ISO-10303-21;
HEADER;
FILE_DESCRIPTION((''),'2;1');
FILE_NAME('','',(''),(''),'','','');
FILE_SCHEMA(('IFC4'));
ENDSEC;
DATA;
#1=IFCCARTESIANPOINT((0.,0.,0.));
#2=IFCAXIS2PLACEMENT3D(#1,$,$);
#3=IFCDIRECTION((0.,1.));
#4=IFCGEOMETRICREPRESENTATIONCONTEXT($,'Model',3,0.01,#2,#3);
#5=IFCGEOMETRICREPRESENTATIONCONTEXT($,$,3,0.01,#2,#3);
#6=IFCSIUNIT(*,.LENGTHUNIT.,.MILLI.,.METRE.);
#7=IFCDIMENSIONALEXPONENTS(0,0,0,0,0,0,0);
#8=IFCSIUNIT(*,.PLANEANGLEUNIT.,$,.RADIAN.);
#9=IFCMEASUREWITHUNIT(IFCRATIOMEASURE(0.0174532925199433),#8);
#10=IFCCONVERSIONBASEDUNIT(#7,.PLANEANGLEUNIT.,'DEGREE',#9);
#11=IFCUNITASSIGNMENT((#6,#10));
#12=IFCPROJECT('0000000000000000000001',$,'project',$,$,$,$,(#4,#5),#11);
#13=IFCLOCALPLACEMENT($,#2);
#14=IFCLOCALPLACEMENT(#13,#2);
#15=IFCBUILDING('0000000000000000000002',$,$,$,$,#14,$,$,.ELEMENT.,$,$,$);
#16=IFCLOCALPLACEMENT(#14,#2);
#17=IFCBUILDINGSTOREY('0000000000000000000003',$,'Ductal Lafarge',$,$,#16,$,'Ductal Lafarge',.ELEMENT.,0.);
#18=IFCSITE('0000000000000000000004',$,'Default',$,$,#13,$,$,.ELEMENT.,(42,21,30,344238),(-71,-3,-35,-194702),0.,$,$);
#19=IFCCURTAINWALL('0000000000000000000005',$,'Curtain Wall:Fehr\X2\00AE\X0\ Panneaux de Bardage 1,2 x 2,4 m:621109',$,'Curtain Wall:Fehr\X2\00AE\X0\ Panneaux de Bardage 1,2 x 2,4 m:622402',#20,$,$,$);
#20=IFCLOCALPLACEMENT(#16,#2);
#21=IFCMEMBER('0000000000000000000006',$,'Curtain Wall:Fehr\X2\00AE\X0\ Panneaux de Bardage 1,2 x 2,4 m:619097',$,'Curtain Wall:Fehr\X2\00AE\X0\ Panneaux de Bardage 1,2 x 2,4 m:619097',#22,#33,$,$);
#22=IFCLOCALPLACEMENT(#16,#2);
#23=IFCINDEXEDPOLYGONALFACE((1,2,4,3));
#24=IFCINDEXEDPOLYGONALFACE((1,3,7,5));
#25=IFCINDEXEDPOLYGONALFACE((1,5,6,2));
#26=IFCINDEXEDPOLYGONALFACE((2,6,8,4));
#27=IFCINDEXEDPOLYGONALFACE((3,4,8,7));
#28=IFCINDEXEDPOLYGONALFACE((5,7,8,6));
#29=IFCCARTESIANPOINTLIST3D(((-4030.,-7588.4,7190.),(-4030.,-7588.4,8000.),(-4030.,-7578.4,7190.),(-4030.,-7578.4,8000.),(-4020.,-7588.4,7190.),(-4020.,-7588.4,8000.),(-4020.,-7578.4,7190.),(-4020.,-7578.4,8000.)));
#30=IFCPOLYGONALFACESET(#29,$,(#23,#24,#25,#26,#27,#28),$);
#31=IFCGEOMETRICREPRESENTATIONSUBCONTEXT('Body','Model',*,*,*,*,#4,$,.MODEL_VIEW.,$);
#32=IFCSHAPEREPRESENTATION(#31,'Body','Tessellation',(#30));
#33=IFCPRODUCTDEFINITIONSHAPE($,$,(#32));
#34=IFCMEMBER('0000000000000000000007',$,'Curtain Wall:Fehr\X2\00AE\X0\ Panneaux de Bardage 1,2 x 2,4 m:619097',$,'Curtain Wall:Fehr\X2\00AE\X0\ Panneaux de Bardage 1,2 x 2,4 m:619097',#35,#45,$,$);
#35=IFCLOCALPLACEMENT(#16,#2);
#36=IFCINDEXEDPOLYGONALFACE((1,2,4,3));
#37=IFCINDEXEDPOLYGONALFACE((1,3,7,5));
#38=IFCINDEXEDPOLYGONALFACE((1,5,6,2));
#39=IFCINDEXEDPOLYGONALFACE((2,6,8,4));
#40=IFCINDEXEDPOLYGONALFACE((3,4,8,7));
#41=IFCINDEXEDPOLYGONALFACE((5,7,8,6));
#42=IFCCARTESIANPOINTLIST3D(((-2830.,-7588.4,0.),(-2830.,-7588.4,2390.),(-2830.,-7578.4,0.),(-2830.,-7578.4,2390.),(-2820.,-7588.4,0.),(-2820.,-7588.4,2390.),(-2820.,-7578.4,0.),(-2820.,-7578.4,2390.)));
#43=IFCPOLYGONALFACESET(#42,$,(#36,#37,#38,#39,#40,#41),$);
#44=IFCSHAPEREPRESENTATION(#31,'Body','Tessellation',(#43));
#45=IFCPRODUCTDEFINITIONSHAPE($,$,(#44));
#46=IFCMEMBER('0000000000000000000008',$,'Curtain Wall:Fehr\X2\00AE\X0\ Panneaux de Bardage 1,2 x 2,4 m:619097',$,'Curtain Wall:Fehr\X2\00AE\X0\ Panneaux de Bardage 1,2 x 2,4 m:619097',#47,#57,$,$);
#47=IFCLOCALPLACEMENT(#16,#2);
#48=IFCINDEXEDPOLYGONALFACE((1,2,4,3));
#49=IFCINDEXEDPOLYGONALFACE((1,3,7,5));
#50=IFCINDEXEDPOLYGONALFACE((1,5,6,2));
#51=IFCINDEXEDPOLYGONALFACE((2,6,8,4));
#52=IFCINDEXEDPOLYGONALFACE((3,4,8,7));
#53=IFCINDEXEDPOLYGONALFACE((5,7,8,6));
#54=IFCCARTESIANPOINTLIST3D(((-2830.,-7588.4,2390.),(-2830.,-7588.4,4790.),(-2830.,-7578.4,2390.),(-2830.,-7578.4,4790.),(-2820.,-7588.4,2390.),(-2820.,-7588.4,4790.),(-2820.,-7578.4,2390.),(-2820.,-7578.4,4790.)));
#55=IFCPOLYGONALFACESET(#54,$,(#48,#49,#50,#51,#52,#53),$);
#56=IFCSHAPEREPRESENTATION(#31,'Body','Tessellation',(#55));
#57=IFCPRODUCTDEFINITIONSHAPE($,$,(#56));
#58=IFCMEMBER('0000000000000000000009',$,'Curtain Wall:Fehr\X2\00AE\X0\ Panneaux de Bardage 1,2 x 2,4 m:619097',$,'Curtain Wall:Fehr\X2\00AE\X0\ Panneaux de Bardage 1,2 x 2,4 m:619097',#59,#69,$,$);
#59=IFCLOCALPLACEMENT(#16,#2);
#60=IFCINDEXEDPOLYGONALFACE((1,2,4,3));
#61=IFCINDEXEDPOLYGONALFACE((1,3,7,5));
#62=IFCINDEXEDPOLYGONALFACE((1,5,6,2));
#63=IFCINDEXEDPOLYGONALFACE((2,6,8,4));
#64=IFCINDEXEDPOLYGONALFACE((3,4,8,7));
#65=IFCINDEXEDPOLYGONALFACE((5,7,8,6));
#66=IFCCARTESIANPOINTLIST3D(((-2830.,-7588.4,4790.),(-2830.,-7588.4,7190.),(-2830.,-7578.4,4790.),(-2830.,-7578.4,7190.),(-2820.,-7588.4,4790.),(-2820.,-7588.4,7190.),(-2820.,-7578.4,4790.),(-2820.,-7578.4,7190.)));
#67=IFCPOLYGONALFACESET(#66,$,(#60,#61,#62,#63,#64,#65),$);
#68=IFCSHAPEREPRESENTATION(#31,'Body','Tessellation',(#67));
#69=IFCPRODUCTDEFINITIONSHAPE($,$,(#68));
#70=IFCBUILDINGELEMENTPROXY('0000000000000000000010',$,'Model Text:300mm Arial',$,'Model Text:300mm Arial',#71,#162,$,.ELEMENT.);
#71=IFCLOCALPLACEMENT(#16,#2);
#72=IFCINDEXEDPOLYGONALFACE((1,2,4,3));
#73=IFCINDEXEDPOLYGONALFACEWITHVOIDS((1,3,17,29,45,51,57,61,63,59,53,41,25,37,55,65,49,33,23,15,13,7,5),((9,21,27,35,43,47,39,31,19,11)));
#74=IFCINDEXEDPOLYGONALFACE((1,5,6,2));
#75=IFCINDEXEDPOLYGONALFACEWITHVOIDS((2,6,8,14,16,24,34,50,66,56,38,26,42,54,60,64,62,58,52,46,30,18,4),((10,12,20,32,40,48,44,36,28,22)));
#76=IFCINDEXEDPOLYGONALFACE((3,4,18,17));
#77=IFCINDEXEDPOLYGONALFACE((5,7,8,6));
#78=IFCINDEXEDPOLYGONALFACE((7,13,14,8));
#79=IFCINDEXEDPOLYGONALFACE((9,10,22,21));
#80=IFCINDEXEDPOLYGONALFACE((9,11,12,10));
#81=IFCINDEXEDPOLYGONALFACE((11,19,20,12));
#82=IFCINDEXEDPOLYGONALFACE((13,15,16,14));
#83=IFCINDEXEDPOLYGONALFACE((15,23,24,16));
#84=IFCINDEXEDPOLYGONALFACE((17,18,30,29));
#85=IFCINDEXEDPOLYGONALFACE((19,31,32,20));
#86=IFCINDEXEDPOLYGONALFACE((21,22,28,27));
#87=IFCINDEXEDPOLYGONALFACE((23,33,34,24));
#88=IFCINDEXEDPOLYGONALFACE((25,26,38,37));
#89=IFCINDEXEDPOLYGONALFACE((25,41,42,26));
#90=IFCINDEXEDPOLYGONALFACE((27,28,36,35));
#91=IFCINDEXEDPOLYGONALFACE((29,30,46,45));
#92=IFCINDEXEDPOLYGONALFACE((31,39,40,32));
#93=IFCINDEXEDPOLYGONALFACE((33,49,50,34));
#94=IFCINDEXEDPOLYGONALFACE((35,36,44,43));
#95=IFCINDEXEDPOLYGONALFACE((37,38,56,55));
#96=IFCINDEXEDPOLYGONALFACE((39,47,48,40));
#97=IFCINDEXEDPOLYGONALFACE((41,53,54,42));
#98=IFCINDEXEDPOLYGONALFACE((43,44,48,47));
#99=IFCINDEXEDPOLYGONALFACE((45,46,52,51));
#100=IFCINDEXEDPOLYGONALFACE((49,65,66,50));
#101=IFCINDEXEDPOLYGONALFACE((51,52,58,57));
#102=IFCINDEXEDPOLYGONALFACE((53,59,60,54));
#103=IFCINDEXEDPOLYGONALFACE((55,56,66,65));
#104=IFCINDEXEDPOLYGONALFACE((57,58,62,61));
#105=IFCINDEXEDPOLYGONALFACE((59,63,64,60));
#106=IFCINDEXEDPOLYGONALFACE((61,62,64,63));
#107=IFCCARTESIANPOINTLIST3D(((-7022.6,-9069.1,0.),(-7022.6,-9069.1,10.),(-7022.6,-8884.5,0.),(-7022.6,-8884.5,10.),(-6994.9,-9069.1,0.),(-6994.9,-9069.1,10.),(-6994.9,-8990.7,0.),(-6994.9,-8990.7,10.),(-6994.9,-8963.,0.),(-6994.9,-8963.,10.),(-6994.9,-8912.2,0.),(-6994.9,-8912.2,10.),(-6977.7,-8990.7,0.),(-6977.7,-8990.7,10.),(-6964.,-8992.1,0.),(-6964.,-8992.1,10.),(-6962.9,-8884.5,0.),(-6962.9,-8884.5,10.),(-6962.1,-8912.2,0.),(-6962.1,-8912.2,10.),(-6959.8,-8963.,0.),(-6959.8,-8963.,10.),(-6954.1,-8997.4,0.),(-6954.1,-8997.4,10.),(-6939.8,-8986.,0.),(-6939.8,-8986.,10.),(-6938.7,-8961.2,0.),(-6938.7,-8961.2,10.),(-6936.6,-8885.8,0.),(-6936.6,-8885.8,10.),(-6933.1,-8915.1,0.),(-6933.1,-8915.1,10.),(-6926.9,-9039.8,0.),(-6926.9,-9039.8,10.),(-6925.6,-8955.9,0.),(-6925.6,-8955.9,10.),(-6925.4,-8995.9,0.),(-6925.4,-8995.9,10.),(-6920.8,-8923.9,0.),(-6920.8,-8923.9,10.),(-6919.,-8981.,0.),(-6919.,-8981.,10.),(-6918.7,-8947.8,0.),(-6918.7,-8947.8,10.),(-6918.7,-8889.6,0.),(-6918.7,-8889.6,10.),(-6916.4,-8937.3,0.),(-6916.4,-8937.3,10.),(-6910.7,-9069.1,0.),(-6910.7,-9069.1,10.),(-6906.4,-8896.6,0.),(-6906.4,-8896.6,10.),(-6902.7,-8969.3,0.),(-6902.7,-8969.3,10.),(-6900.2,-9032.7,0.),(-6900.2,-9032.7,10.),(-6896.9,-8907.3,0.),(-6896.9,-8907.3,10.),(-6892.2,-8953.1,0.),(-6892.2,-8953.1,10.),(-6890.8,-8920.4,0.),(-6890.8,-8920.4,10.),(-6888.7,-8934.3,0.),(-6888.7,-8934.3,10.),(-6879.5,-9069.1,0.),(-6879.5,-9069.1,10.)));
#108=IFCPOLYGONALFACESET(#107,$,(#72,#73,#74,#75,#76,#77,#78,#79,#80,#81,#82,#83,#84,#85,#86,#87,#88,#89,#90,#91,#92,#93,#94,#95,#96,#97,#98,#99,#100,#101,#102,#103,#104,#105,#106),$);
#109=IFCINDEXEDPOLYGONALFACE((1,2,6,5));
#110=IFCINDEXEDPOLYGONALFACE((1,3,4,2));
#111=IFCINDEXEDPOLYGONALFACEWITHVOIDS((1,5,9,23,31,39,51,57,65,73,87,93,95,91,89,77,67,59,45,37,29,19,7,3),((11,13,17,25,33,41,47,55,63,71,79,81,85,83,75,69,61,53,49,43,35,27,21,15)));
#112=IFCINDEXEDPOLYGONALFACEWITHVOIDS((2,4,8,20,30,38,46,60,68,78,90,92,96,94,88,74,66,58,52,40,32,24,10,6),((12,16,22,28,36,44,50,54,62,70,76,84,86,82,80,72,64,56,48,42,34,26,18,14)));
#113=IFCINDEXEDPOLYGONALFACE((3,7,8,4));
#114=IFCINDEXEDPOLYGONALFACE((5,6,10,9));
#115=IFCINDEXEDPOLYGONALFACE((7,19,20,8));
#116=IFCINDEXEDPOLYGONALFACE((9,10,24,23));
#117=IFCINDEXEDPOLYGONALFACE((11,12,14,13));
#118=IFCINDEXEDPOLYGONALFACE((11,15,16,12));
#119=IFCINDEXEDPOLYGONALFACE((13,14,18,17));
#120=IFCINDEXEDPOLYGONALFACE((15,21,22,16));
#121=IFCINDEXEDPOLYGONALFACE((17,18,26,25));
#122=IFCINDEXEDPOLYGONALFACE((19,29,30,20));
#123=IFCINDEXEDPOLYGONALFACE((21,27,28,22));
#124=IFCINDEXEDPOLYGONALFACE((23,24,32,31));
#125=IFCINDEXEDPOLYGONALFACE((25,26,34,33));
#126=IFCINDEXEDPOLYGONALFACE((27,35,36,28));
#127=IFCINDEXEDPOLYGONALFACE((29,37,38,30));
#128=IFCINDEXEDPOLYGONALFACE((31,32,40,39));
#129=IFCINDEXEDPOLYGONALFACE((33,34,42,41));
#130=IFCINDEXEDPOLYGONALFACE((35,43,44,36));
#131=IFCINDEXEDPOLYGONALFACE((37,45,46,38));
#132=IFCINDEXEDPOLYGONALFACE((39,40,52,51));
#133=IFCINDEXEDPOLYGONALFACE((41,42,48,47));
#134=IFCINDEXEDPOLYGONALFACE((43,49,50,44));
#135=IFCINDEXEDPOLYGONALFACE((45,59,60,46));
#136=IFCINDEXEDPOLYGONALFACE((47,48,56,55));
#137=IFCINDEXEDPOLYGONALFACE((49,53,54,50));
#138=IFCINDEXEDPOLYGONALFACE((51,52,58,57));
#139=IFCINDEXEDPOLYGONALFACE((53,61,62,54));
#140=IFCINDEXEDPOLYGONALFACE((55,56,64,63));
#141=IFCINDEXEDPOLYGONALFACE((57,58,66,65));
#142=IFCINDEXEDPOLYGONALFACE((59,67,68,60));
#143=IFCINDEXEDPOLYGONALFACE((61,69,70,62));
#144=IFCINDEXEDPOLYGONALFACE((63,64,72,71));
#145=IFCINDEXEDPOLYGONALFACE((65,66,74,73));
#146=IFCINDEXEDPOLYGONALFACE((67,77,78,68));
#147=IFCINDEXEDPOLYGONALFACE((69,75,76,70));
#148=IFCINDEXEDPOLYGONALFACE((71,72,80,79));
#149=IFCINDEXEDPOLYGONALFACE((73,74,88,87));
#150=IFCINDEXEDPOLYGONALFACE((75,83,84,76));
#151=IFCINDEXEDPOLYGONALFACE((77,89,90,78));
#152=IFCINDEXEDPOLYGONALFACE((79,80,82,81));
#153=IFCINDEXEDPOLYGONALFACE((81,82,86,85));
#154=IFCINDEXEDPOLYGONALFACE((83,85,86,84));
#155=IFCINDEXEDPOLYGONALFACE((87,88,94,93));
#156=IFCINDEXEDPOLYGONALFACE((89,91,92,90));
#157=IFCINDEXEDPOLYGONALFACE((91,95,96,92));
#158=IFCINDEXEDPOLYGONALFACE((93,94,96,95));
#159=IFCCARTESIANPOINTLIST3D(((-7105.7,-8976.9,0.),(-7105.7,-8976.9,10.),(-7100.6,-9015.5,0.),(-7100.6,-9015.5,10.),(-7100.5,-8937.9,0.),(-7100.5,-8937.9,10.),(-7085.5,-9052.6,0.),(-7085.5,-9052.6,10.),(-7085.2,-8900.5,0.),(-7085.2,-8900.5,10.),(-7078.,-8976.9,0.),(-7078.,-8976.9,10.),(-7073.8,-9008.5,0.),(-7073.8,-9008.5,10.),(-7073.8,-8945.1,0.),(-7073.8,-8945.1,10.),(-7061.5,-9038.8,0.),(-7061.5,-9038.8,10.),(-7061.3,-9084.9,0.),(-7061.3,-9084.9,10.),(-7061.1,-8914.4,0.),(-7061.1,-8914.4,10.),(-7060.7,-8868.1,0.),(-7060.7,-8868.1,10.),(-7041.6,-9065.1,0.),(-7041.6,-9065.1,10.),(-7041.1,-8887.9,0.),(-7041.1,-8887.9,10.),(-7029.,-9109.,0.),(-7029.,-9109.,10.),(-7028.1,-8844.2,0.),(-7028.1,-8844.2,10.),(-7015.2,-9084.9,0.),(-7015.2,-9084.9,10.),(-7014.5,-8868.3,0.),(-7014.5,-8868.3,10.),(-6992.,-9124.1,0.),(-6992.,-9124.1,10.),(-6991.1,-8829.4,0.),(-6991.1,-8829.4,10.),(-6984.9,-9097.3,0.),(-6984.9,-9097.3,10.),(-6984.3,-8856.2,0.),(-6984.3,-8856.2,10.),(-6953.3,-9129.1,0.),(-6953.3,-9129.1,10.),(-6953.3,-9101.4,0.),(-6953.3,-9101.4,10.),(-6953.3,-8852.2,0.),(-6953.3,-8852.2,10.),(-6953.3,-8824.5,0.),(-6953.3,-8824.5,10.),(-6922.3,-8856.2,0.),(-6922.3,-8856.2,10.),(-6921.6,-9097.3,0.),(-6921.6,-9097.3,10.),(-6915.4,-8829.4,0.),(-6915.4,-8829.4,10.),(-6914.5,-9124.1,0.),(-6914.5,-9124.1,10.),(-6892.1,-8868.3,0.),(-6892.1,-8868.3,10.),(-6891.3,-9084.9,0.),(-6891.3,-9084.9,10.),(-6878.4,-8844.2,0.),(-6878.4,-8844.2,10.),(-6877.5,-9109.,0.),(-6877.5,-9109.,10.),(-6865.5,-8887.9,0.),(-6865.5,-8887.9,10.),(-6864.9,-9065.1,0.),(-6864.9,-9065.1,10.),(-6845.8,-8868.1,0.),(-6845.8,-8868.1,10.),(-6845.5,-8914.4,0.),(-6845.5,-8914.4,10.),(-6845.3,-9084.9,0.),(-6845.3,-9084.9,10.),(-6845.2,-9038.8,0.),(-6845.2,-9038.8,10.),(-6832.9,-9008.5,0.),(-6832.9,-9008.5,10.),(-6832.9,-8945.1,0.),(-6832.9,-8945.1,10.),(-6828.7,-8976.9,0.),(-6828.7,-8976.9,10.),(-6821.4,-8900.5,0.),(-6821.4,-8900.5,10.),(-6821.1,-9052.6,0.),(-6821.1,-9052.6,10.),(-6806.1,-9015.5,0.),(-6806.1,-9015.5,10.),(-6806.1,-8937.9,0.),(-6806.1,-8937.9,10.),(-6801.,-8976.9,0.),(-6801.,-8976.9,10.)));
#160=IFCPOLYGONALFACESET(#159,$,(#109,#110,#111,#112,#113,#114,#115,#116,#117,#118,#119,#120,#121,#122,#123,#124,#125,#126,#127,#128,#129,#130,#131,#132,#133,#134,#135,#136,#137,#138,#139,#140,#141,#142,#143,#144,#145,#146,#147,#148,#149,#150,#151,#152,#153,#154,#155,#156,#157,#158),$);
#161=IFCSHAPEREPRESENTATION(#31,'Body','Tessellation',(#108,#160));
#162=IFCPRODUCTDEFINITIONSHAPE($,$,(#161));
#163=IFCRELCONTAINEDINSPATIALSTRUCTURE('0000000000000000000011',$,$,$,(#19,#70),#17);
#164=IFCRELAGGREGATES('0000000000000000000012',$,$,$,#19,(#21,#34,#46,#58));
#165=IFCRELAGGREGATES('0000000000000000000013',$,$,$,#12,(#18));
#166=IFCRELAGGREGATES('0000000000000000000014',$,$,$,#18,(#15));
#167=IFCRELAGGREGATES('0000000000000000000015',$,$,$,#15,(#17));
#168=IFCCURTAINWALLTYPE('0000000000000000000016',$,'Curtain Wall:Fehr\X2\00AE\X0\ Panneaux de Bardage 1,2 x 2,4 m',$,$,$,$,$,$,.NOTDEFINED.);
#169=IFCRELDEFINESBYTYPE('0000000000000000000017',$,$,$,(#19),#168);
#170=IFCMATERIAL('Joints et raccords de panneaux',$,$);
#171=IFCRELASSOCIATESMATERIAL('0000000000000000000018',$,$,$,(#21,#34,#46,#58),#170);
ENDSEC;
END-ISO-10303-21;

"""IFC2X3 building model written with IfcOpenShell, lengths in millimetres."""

from ifc_helpers import new_model, entity, si_unit, converted_unit, direction, frame, origin, origin_2d_with_axis, place, context, subcontext, project, spatial, polyline, rectangle, outline, extrude, material, type_object, element, aggregate, save


model = new_model("IFC2X3")

# Units and contexts
model_context = context("Model", 3, precision=0.01, world=origin(), true_north=direction((0.0, 1.0)))
context_of_model = context(None, 3, precision=0.01, world=origin(), true_north=direction((0.0, 1.0)))
body_context = subcontext(model_context, "Body", "Model", "MODEL_VIEW")
ifc_project = project(units=[si_unit("LENGTHUNIT", "METRE", prefix="MILLI"), converted_unit("PLANEANGLEUNIT", "DEGREE", entity("IfcRatioMeasure", 0.0174532925199433), si_unit("PLANEANGLEUNIT", "RADIAN"), dimensions=[0, 0, 0, 0, 0, 0, 0])], contexts=[model_context, context_of_model])

# Site, building, storey
site_placement = place(None, origin())
site = spatial("IfcSite", under=ifc_project, at=site_placement, Name="Default", CompositionType="ELEMENT", RefLatitude=(42, 21, 30, 344238), RefLongitude=(-71, -3, -35, -194702), RefElevation=0.0)
building_placement = place(site_placement, origin())
building = spatial("IfcBuilding", under=site, at=building_placement, CompositionType="ELEMENT")
storey_placement = place(building_placement, origin())
storey = spatial("IfcBuildingStorey", under=building, at=storey_placement, Name="Ductal Lafarge", LongName="Ductal Lafarge", CompositionType="ELEMENT", Elevation=0.0)

# Curtain wall, members
curtain_wall_type = type_object("IfcCurtainWallType", Name="Curtain Wall:Fehr® Panneaux de Bardage 1,2 x 2,4 m", PredefinedType="NOTDEFINED")
curtain_wall_placement = place(storey_placement, origin())
curtain_wall = element("IfcCurtainWall", 1, at=curtain_wall_placement, inside=storey, type_object=curtain_wall_type, Name="Curtain Wall:Fehr® Panneaux de Bardage 1,2 x 2,4 m:621109", ObjectType="Curtain Wall:Fehr® Panneaux de Bardage 1,2 x 2,4 m:622402")
ifc_material = material(Name="Joints et raccords de panneaux")
member_1_placement = place(curtain_wall_placement, frame((-4030.0, -7588.4, 7190.0)))
member_1 = element("IfcMember", 2, at=member_1_placement, material=ifc_material, Name="Curtain Wall:Fehr® Panneaux de Bardage 1,2 x 2,4 m:619097", ObjectType="Curtain Wall:Fehr® Panneaux de Bardage 1,2 x 2,4 m:619097", context=body_context, shape_type="SweptSolid", body=[
    extrude(rectangle(XDim=10.0, YDim=10.0, at=origin_2d_with_axis()), frame((5.0, 5.0, 0.0), z_axis=(0.0, 0.0, 1.0), x_axis=(0.0, 1.0, 0.0)), (0.0, 0.0, 1.0), 810.0),
])
member_2_placement = place(curtain_wall_placement, frame((-2830.0, -7588.4, 0.0)))
member_2 = element("IfcMember", 3, at=member_2_placement, material=ifc_material, Name="Curtain Wall:Fehr® Panneaux de Bardage 1,2 x 2,4 m:619097", ObjectType="Curtain Wall:Fehr® Panneaux de Bardage 1,2 x 2,4 m:619097", context=body_context, shape_type="SweptSolid", body=[
    extrude(rectangle(XDim=10.0, YDim=10.0, at=origin_2d_with_axis()), frame((5.0, 5.0, 0.0), z_axis=(0.0, 0.0, 1.0), x_axis=(0.0, 1.0, 0.0)), (0.0, 0.0, 1.0), 2390.0),
])
member_3_placement = place(curtain_wall_placement, frame((-2830.0, -7588.4, 2390.0)))
member_3 = element("IfcMember", 4, at=member_3_placement, material=ifc_material, Name="Curtain Wall:Fehr® Panneaux de Bardage 1,2 x 2,4 m:619097", ObjectType="Curtain Wall:Fehr® Panneaux de Bardage 1,2 x 2,4 m:619097", context=body_context, shape_type="SweptSolid", body=[
    extrude(rectangle(XDim=10.0, YDim=10.0, at=origin_2d_with_axis()), frame((5.0, 5.0, 0.0), z_axis=(0.0, 0.0, 1.0), x_axis=(0.0, 1.0, 0.0)), (0.0, 0.0, 1.0), 2400.0),
])
member_4_placement = place(curtain_wall_placement, frame((-2830.0, -7588.4, 4790.0)))
member_4 = element("IfcMember", 5, at=member_4_placement, material=ifc_material, Name="Curtain Wall:Fehr® Panneaux de Bardage 1,2 x 2,4 m:619097", ObjectType="Curtain Wall:Fehr® Panneaux de Bardage 1,2 x 2,4 m:619097", context=body_context, shape_type="SweptSolid", body=[
    extrude(rectangle(XDim=10.0, YDim=10.0, at=origin_2d_with_axis()), frame((5.0, 5.0, 0.0), z_axis=(0.0, 0.0, 1.0), x_axis=(0.0, 1.0, 0.0)), (0.0, 0.0, 1.0), 2400.0),
])
aggregate(curtain_wall, [member_1, member_2, member_3, member_4])

# Building element proxy
proxy_1_placement = place(storey_placement, frame((-7105.7, -9129.1, 0.0)))
element("IfcBuildingElementProxy", 6, at=proxy_1_placement, inside=storey, Name="Model Text:300mm Arial", ObjectType="Model Text:300mm Arial", CompositionType="ELEMENT", context=body_context, shape_type="SweptSolid", body=[
    extrude(outline(polyline([(-86.6, -94.9), (-58.9, -94.9), (-58.9, -16.4), (-41.7, -16.4), (-28.0, -17.8), (-18.1, -23.2), (9.1, -65.6), (25.3, -94.9), (56.5, -94.9), (35.8, -58.4), (10.6, -21.6), (-3.8, -11.8), (17.0, -6.7), (33.3, 5.0), (43.8, 21.2), (47.3, 40.0), (45.2, 53.9), (39.1, 66.9), (29.6, 77.7), (17.3, 84.7), (-0.6, 88.5), (-26.9, 89.8), (-86.6, 89.8), (-86.6, -94.9)]), holes=[polyline([(-58.9, 11.3), (-58.9, 62.1), (-26.1, 62.1), (2.9, 59.2), (15.2, 50.4), (19.6, 37.0), (17.3, 26.5), (10.4, 18.3), (-2.7, 13.1), (-23.8, 11.3), (-58.9, 11.3)])]), frame((169.7, 154.9, 0.0)), (0.0, 0.0, 1.0), 10.0),
    extrude(outline(polyline([(-19.6, -150.9), (18.6, -150.9), (57.1, -141.0), (92.5, -121.5), (121.0, -92.5), (141.0, -57.4), (151.1, -19.4), (151.1, 19.5), (140.9, 58.3), (121.0, 93.4), (92.2, 121.5), (57.4, 141.2), (19.6, 151.2), (-19.4, 151.2), (-58.1, 141.0), (-93.2, 121.2), (-121.3, 92.3), (-141.0, 57.5), (-150.9, 19.8), (-150.9, -19.4), (-140.6, -58.5), (-120.5, -93.8), (-91.4, -121.7), (-56.6, -141.1), (-19.6, -150.9)]), holes=[polyline([(-16.1, -123.4), (-46.2, -115.4), (-74.7, -99.6), (-98.5, -76.7), (-114.9, -47.8), (-123.4, -15.8), (-123.5, 16.3), (-115.3, 47.1), (-99.2, 75.5), (-76.2, 99.1), (-47.5, 115.3), (-15.8, 123.7), (16.1, 123.7), (46.9, 115.6), (75.4, 99.4), (99.0, 76.3), (115.3, 47.7), (123.7, 16.0), (123.7, -15.9), (115.4, -46.9), (98.9, -75.6), (75.6, -99.3), (46.7, -115.3), (15.2, -123.4), (-16.1, -123.4)])]), frame((152.4, 152.5, 0.0), z_axis=(0.0, 0.0, 1.0), x_axis=(-0.991656, -0.128915, 0.0)), (0.0, 0.0, 1.0), 10.0),
])

save(model, "model.ifc")
